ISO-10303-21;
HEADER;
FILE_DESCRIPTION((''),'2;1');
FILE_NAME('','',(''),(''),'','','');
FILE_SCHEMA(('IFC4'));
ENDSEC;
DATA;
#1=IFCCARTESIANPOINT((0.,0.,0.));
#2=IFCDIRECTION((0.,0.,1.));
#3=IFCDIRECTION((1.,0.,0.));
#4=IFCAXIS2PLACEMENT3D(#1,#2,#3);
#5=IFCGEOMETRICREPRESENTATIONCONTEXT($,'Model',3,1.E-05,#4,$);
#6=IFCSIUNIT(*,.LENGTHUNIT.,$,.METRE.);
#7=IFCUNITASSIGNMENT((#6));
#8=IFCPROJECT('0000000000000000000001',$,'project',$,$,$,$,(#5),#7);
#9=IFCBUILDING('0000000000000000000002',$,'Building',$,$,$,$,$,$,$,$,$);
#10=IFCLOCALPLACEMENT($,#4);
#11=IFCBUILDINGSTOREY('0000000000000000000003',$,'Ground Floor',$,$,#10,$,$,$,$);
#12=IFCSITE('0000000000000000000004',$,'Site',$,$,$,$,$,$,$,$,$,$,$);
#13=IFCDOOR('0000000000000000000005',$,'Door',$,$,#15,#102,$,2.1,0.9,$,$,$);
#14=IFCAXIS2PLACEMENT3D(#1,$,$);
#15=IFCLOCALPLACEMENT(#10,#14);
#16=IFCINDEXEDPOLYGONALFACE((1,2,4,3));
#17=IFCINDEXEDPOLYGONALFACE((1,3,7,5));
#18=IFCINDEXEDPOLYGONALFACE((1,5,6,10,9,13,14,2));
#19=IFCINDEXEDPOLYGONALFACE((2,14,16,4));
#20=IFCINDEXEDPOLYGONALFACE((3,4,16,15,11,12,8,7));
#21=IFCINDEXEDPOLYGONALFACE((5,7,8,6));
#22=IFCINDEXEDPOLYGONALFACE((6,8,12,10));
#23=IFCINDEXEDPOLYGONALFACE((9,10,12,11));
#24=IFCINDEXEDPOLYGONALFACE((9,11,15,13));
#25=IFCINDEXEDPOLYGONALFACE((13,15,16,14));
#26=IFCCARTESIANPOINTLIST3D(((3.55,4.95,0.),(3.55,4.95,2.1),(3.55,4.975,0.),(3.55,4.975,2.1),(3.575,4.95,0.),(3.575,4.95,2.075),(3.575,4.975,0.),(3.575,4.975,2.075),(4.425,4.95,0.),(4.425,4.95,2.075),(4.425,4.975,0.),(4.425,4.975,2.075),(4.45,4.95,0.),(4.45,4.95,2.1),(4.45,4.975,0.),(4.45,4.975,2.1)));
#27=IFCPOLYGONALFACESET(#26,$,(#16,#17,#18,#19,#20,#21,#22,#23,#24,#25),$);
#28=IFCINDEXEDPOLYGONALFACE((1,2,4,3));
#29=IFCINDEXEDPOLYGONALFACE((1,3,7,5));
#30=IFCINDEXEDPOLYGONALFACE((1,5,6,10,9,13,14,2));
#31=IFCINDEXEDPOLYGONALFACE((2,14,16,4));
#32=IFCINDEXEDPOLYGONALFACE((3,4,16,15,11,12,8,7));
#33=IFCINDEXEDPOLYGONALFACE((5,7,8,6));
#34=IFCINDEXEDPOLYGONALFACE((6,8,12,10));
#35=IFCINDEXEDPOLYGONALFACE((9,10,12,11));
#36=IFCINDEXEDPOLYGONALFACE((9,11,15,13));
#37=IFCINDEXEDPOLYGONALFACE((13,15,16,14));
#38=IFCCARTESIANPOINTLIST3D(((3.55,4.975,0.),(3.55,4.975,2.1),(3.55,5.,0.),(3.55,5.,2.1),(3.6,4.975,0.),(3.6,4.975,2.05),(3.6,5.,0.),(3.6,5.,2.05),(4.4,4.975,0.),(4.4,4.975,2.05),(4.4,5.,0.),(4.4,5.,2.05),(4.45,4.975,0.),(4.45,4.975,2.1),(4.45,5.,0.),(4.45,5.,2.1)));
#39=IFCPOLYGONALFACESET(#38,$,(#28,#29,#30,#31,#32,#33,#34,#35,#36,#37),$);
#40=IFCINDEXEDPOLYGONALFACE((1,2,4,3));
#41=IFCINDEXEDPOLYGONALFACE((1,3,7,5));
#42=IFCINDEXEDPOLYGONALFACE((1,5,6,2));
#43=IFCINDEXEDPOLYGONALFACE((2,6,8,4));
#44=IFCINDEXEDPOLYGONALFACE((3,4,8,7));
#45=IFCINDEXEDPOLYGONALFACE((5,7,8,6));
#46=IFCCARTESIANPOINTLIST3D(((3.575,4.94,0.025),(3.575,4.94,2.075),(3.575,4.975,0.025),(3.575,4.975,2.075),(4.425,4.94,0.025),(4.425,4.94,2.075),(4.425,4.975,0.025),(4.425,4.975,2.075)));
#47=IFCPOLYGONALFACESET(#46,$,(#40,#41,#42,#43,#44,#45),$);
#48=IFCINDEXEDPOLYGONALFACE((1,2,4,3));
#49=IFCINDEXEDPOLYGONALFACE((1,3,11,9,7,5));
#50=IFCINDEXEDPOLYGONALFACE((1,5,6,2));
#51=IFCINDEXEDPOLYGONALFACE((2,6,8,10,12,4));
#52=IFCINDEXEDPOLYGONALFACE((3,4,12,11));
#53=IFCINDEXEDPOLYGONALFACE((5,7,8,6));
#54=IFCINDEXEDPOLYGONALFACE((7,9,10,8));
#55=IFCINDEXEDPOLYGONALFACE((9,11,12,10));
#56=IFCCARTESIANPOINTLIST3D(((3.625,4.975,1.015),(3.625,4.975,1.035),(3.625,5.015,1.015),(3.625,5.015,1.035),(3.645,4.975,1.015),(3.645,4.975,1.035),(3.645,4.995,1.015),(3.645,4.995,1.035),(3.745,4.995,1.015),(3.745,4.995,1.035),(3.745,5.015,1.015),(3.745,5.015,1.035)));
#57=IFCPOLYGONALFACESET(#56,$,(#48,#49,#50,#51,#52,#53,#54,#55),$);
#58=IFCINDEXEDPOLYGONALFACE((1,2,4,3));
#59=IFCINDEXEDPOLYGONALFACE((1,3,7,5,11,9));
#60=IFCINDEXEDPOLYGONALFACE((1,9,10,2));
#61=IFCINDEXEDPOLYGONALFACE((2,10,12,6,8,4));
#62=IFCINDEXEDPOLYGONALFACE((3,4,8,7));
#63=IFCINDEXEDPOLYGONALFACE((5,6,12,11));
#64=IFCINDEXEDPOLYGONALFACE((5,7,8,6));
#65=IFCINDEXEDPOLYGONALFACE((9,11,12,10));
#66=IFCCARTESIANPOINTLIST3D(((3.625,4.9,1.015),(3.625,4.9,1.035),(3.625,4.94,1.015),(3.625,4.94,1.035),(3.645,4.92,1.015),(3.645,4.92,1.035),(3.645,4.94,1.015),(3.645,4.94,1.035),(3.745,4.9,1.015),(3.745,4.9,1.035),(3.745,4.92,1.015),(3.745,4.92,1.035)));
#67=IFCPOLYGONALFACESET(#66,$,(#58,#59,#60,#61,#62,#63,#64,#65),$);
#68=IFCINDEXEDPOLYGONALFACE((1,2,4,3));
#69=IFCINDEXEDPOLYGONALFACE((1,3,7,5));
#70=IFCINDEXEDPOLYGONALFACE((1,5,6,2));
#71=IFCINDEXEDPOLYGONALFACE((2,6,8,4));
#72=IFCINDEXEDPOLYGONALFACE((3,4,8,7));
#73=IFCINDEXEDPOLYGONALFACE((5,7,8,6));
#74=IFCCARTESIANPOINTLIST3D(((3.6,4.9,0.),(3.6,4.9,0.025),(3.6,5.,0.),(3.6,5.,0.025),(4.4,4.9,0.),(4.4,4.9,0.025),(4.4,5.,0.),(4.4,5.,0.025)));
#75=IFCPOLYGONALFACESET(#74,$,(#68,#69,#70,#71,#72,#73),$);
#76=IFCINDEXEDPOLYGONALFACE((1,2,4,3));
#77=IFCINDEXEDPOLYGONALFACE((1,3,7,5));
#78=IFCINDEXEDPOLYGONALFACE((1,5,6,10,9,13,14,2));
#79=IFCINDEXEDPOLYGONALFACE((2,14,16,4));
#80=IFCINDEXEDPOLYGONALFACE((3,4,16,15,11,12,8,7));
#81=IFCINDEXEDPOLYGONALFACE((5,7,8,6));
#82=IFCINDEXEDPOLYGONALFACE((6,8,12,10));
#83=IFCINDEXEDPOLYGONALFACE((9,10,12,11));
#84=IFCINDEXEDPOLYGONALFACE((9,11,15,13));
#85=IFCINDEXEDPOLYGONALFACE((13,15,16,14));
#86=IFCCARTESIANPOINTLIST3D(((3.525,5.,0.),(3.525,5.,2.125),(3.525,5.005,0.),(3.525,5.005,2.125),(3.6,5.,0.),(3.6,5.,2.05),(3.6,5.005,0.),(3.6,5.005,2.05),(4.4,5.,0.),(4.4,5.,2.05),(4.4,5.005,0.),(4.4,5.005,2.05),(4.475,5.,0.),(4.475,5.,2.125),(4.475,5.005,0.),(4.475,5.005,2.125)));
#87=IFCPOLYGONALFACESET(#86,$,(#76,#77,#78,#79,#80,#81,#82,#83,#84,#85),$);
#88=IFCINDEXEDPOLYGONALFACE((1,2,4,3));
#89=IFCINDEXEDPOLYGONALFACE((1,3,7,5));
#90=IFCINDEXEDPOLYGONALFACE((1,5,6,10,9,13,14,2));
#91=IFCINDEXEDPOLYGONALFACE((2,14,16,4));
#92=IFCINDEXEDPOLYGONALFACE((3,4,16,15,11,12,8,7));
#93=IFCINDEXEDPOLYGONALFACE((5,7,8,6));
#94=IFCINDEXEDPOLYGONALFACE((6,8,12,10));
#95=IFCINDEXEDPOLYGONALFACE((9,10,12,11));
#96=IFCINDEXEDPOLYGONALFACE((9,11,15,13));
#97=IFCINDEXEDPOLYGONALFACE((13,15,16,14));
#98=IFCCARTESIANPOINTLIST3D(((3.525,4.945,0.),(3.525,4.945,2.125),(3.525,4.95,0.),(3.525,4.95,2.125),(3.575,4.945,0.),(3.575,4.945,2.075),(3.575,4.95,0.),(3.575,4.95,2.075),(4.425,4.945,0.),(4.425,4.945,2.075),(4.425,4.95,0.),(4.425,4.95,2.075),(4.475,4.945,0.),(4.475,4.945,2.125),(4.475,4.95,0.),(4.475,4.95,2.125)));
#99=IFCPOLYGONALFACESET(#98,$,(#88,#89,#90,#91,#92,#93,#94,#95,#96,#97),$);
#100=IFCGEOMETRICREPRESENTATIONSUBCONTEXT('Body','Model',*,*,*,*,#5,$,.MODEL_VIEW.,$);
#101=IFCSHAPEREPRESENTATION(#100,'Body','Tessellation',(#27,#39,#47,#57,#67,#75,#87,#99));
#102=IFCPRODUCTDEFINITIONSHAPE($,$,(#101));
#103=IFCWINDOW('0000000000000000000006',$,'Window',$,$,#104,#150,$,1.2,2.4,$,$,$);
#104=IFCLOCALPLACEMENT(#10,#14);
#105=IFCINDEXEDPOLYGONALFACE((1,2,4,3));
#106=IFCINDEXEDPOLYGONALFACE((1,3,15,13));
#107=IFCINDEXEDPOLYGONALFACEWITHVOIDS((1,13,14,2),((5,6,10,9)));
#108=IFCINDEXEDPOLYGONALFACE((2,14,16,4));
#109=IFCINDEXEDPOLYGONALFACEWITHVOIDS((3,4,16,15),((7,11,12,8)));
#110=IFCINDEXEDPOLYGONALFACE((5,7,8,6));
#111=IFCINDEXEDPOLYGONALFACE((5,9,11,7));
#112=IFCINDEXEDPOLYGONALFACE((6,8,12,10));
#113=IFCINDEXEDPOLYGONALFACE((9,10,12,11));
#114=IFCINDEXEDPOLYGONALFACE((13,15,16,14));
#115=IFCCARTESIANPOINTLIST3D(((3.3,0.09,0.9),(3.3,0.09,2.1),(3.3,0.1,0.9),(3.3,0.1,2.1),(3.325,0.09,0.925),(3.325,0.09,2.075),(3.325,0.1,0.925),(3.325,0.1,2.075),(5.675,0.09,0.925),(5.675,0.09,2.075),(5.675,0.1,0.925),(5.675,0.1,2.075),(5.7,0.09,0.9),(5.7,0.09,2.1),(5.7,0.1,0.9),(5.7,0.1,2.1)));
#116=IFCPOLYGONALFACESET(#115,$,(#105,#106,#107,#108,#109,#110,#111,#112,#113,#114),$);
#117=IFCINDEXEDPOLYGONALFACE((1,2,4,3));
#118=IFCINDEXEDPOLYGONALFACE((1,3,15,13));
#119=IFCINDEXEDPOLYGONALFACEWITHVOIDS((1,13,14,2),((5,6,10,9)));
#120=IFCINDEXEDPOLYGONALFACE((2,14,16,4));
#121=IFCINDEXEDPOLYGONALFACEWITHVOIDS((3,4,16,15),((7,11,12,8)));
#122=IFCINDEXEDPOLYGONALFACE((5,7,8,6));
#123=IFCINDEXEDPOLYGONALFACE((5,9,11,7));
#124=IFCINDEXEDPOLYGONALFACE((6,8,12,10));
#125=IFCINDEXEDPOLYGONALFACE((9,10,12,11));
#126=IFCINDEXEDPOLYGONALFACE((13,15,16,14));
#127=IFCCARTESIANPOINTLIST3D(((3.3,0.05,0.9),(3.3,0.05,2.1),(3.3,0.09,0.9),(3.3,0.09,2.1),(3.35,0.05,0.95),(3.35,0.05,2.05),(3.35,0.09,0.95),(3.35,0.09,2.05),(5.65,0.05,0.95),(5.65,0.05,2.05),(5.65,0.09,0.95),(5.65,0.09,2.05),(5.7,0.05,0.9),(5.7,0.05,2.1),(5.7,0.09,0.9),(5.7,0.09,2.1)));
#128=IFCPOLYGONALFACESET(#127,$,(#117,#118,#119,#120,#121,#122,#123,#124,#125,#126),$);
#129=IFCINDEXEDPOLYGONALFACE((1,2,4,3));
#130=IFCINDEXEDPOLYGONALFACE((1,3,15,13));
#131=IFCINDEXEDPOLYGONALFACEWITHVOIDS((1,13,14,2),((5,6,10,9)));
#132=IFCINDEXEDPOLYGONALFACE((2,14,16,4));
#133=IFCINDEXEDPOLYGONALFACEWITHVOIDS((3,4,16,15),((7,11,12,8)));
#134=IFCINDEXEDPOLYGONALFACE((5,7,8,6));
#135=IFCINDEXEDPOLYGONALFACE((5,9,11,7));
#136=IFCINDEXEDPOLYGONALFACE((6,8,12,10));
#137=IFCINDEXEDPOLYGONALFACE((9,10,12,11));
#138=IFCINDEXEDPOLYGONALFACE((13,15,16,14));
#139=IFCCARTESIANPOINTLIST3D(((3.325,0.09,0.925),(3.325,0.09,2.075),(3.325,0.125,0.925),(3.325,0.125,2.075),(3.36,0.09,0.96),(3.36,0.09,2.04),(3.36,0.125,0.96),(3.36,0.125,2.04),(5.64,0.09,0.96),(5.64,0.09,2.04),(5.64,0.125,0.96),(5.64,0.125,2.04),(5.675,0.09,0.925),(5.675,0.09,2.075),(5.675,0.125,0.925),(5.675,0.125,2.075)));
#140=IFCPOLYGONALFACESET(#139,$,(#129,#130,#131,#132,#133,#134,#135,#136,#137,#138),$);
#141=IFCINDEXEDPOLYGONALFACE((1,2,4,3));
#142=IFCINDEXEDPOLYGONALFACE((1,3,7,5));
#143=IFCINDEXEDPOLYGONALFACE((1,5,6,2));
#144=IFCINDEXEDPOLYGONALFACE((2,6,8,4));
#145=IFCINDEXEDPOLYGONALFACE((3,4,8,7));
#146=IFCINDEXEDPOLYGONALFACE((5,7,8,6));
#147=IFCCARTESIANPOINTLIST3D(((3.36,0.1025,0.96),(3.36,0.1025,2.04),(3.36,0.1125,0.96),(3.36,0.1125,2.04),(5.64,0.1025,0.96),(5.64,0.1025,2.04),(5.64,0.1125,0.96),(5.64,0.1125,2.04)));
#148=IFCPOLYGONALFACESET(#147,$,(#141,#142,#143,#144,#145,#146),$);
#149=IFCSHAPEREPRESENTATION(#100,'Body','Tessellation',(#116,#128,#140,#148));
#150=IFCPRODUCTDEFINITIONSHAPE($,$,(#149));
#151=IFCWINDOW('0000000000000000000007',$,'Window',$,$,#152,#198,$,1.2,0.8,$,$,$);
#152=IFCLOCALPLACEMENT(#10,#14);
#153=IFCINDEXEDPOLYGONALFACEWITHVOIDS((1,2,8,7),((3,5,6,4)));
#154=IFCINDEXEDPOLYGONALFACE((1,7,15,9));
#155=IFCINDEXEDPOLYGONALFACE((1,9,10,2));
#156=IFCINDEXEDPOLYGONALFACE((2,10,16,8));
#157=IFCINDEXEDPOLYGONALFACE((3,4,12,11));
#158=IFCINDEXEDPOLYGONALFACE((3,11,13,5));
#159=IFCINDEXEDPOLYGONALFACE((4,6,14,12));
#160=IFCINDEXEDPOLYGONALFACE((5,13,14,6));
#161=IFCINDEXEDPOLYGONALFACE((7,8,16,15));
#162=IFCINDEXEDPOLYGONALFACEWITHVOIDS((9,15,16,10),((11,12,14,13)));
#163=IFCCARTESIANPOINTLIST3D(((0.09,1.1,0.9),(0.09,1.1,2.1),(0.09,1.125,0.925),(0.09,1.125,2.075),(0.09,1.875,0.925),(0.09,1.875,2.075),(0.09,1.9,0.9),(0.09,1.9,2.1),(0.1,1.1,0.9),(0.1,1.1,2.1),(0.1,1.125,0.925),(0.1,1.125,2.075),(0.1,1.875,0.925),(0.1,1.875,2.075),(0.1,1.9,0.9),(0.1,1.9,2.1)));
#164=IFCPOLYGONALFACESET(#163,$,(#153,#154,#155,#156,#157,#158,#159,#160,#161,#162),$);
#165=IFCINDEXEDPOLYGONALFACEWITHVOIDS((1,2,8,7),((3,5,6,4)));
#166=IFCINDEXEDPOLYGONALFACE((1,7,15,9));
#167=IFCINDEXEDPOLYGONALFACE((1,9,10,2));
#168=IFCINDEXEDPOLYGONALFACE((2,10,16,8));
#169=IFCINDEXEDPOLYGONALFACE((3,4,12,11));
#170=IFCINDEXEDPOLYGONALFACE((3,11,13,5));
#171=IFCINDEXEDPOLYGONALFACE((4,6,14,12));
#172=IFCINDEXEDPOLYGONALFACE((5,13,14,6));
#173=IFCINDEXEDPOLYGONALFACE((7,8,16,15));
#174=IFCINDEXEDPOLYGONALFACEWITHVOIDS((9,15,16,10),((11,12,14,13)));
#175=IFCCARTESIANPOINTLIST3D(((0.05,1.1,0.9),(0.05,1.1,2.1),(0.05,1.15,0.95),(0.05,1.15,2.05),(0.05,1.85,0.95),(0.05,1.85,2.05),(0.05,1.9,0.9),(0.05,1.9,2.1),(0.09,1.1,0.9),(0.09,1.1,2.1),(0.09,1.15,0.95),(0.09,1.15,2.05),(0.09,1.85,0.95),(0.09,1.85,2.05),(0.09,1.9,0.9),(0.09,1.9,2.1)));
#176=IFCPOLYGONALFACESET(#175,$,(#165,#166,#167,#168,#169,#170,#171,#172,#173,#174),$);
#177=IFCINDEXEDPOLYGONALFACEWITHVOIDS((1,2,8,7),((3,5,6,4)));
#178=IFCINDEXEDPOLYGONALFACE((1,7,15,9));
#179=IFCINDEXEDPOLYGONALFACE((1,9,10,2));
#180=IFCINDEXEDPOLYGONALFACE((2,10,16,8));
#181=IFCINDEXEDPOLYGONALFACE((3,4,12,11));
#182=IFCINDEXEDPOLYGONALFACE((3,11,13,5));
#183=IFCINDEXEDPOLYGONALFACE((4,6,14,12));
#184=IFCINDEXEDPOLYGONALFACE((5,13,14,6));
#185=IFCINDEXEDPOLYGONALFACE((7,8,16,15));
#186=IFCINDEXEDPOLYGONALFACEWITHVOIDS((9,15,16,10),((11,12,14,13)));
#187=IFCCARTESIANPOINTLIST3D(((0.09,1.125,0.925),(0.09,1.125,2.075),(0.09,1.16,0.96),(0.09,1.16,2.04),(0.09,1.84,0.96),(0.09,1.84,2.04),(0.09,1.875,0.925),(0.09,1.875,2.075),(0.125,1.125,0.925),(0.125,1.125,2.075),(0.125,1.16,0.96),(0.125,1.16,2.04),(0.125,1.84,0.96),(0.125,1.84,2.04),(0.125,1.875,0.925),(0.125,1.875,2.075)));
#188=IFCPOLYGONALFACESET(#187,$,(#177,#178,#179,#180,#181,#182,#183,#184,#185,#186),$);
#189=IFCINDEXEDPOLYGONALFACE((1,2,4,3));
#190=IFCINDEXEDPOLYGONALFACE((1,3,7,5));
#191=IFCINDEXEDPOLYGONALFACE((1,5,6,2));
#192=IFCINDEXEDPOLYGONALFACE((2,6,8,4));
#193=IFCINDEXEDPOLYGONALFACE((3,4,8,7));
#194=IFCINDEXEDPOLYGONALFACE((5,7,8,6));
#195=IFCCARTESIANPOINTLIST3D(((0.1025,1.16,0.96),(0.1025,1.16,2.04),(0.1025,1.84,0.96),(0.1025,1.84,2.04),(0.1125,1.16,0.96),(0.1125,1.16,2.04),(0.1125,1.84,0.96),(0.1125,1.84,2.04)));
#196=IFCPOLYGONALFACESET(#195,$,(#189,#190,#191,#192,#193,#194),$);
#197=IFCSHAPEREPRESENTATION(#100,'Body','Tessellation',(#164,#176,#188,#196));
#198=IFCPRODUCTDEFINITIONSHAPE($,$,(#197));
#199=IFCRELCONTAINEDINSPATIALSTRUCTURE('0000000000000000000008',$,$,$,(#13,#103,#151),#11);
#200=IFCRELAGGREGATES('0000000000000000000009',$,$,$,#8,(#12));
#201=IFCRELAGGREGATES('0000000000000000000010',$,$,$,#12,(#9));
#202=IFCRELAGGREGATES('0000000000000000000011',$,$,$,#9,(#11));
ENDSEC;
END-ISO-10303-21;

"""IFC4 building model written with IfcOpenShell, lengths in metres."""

from ifc_helpers import new_model, si_unit, frame, origin_with_axes, place, context, subcontext, project, spatial, line, indexed_curve, outline, extrude, element, save


model = new_model("IFC4")

# Units and contexts
model_context = context("Model", 3, precision=1e-05, world=origin_with_axes())
body_context = subcontext(model_context, "Body", "Model", "MODEL_VIEW")
ifc_project = project(units=[si_unit("LENGTHUNIT", "METRE")], contexts=[model_context])

# Site, building, storey
site = spatial("IfcSite", under=ifc_project, Name="Site")
building = spatial("IfcBuilding", under=site, Name="Building")
storey_placement = place(None, origin_with_axes())
storey = spatial("IfcBuildingStorey", under=building, at=storey_placement, Name="Ground Floor")

# Door
door_1_placement = place(storey_placement, frame((4.45, 5.0, 0.0), z_axis=(0.0, 0.0, 1.0), x_axis=(-1.0, 0.0, 0.0)))
element("IfcDoor", 1, at=door_1_placement, inside=storey, Name="Door", OverallHeight=2.1, OverallWidth=0.9, context=body_context, shape_type="SweptSolid", body=[
    extrude(outline(indexed_curve([(0.0, 0.0), (0.0, 2.1), (0.9, 2.1), (0.9, 0.0), (0.875, 0.0), (0.875, 2.075), (0.025, 2.075), (0.025, 0.0)], segments=[line(1, 2, 3, 4, 5, 6, 7, 8, 1)])), frame((0.0, 0.025, 0.0), z_axis=(0.0, -1.0, 0.0), x_axis=(1.0, 0.0, 0.0)), (0.0, 0.0, -1.0), 0.025),
    extrude(outline(indexed_curve([(0.0, 0.0), (0.0, 2.1), (0.9, 2.1), (0.9, 0.0), (0.85, 0.0), (0.85, 2.05), (0.05, 2.05), (0.05, 0.0)], segments=[line(1, 2, 3, 4, 5, 6, 7, 8, 1)])), frame((0.0, 0.0, 0.0), z_axis=(0.0, -1.0, 0.0), x_axis=(1.0, 0.0, 0.0)), (0.0, 0.0, -1.0), 0.025),
    extrude(outline(indexed_curve([(0.0, 0.0), (0.85, 0.0), (0.85, 0.035), (0.0, 0.035)], segments=[line(1, 2, 3, 4, 1)])), frame((0.025, 0.025, 0.025), z_axis=(0.0, 0.0, 1.0), x_axis=(1.0, 0.0, 0.0)), (0.0, 0.0, 1.0), 2.05),
    extrude(outline(indexed_curve([(0.0, 0.0), (0.0, -0.04), (-0.12, -0.04), (-0.12, -0.02), (-0.02, -0.02), (-0.02, 0.0)], segments=[line(1, 2, 3, 4, 5, 6, 1)])), frame((0.825, 0.025, 1.015), z_axis=(0.0, 0.0, 1.0), x_axis=(1.0, 0.0, 0.0)), (0.0, 0.0, 1.0), 0.02),
    extrude(outline(indexed_curve([(0.0, 0.0), (0.0, 0.04), (-0.12, 0.04), (-0.12, 0.02), (-0.02, 0.02), (-0.02, 0.0)], segments=[line(1, 2, 3, 4, 5, 6, 1)])), frame((0.825, 0.06, 1.015), z_axis=(0.0, 0.0, 1.0), x_axis=(1.0, 0.0, 0.0)), (0.0, 0.0, 1.0), 0.02),
    extrude(outline(indexed_curve([(0.0, 0.0), (0.8, 0.0), (0.8, 0.1), (0.0, 0.1)], segments=[line(1, 2, 3, 4, 1)])), frame((0.05, 0.0, 0.0), z_axis=(0.0, 0.0, 1.0), x_axis=(1.0, 0.0, 0.0)), (0.0, 0.0, 1.0), 0.025),
    extrude(outline(indexed_curve([(0.0, 0.0), (0.0, 2.125), (0.95, 2.125), (0.95, 0.0), (0.875, 0.0), (0.875, 2.05), (0.075, 2.05), (0.075, 0.0)], segments=[line(1, 2, 3, 4, 5, 6, 7, 8, 1)])), frame((-0.025, -0.005, 0.0), z_axis=(0.0, -1.0, 0.0), x_axis=(1.0, 0.0, 0.0)), (0.0, 0.0, -1.0), 0.005),
    extrude(outline(indexed_curve([(0.0, 0.0), (0.0, 2.125), (0.95, 2.125), (0.95, 0.0), (0.9, 0.0), (0.9, 2.075), (0.05, 2.075), (0.05, 0.0)], segments=[line(1, 2, 3, 4, 5, 6, 7, 8, 1)])), frame((-0.025, 0.05, 0.0), z_axis=(0.0, -1.0, 0.0), x_axis=(1.0, 0.0, 0.0)), (0.0, 0.0, -1.0), 0.005),
])

# Windows
window_1_placement = place(storey_placement, frame((3.3, 0.0, 0.9), z_axis=(0.0, 0.0, 1.0), x_axis=(1.0, 0.0, 0.0)))
element("IfcWindow", 2, at=window_1_placement, inside=storey, Name="Window", OverallHeight=1.2, OverallWidth=2.4, context=body_context, shape_type="SweptSolid", body=[
    extrude(outline(indexed_curve([(0.0, 0.0), (2.4, 0.0), (2.4, 1.2), (0.0, 1.2)], segments=[line(1, 2, 3, 4, 1)]), holes=[indexed_curve([(0.025, 0.025), (2.375, 0.025), (2.375, 1.175), (0.025, 1.175)], segments=[line(1, 2, 3, 4, 1)])]), frame((0.0, 0.09, 0.0), z_axis=(0.0, -1.0, 0.0), x_axis=(1.0, 0.0, 0.0)), (0.0, 0.0, -1.0), 0.01),
    extrude(outline(indexed_curve([(0.0, 0.0), (2.4, 0.0), (2.4, 1.2), (0.0, 1.2)], segments=[line(1, 2, 3, 4, 1)]), holes=[indexed_curve([(0.05, 0.05), (2.35, 0.05), (2.35, 1.15), (0.05, 1.15)], segments=[line(1, 2, 3, 4, 1)])]), frame((0.0, 0.05, 0.0), z_axis=(0.0, -1.0, 0.0), x_axis=(1.0, 0.0, 0.0)), (0.0, 0.0, -1.0), 0.04),
    extrude(outline(indexed_curve([(0.0, 0.0), (2.35, 0.0), (2.35, 1.15), (0.0, 1.15)], segments=[line(1, 2, 3, 4, 1)]), holes=[indexed_curve([(0.035, 0.035), (2.315, 0.035), (2.315, 1.115), (0.035, 1.115)], segments=[line(1, 2, 3, 4, 1)])]), frame((0.025, 0.09, 0.025), z_axis=(0.0, -1.0, 0.0), x_axis=(1.0, 0.0, 0.0)), (0.0, 0.0, -1.0), 0.035),
    extrude(outline(indexed_curve([(0.035, 0.035), (2.315, 0.035), (2.315, 1.115), (0.035, 1.115)], segments=[line(1, 2, 3, 4, 1)])), frame((0.025, 0.1025, 0.025), z_axis=(0.0, -1.0, 0.0), x_axis=(1.0, 0.0, 0.0)), (0.0, 0.0, -1.0), 0.01),
])
window_2_placement = place(storey_placement, frame((0.0, 1.9, 0.9), z_axis=(0.0, 0.0, 1.0), x_axis=(0.0, -1.0, 0.0)))
element("IfcWindow", 3, at=window_2_placement, inside=storey, Name="Window", OverallHeight=1.2, OverallWidth=0.8, context=body_context, shape_type="SweptSolid", body=[
    extrude(outline(indexed_curve([(0.0, 0.0), (0.8, 0.0), (0.8, 1.2), (0.0, 1.2)], segments=[line(1, 2, 3, 4, 1)]), holes=[indexed_curve([(0.025, 0.025), (0.775, 0.025), (0.775, 1.175), (0.025, 1.175)], segments=[line(1, 2, 3, 4, 1)])]), frame((0.0, 0.09, 0.0), z_axis=(0.0, -1.0, 0.0), x_axis=(1.0, 0.0, 0.0)), (0.0, 0.0, -1.0), 0.01),
    extrude(outline(indexed_curve([(0.0, 0.0), (0.8, 0.0), (0.8, 1.2), (0.0, 1.2)], segments=[line(1, 2, 3, 4, 1)]), holes=[indexed_curve([(0.05, 0.05), (0.75, 0.05), (0.75, 1.15), (0.05, 1.15)], segments=[line(1, 2, 3, 4, 1)])]), frame((0.0, 0.05, 0.0), z_axis=(0.0, -1.0, 0.0), x_axis=(1.0, 0.0, 0.0)), (0.0, 0.0, -1.0), 0.04),
    extrude(outline(indexed_curve([(0.0, 0.0), (0.75, 0.0), (0.75, 1.15), (0.0, 1.15)], segments=[line(1, 2, 3, 4, 1)]), holes=[indexed_curve([(0.035, 0.035), (0.715, 0.035), (0.715, 1.115), (0.035, 1.115)], segments=[line(1, 2, 3, 4, 1)])]), frame((0.025, 0.09, 0.025), z_axis=(0.0, -1.0, 0.0), x_axis=(1.0, 0.0, 0.0)), (0.0, 0.0, -1.0), 0.035),
    extrude(outline(indexed_curve([(0.035, 0.035), (0.715, 0.035), (0.715, 1.115), (0.035, 1.115)], segments=[line(1, 2, 3, 4, 1)])), frame((0.025, 0.1025, 0.025), z_axis=(0.0, -1.0, 0.0), x_axis=(1.0, 0.0, 0.0)), (0.0, 0.0, -1.0), 0.01),
])

save(model, "model.ifc")
